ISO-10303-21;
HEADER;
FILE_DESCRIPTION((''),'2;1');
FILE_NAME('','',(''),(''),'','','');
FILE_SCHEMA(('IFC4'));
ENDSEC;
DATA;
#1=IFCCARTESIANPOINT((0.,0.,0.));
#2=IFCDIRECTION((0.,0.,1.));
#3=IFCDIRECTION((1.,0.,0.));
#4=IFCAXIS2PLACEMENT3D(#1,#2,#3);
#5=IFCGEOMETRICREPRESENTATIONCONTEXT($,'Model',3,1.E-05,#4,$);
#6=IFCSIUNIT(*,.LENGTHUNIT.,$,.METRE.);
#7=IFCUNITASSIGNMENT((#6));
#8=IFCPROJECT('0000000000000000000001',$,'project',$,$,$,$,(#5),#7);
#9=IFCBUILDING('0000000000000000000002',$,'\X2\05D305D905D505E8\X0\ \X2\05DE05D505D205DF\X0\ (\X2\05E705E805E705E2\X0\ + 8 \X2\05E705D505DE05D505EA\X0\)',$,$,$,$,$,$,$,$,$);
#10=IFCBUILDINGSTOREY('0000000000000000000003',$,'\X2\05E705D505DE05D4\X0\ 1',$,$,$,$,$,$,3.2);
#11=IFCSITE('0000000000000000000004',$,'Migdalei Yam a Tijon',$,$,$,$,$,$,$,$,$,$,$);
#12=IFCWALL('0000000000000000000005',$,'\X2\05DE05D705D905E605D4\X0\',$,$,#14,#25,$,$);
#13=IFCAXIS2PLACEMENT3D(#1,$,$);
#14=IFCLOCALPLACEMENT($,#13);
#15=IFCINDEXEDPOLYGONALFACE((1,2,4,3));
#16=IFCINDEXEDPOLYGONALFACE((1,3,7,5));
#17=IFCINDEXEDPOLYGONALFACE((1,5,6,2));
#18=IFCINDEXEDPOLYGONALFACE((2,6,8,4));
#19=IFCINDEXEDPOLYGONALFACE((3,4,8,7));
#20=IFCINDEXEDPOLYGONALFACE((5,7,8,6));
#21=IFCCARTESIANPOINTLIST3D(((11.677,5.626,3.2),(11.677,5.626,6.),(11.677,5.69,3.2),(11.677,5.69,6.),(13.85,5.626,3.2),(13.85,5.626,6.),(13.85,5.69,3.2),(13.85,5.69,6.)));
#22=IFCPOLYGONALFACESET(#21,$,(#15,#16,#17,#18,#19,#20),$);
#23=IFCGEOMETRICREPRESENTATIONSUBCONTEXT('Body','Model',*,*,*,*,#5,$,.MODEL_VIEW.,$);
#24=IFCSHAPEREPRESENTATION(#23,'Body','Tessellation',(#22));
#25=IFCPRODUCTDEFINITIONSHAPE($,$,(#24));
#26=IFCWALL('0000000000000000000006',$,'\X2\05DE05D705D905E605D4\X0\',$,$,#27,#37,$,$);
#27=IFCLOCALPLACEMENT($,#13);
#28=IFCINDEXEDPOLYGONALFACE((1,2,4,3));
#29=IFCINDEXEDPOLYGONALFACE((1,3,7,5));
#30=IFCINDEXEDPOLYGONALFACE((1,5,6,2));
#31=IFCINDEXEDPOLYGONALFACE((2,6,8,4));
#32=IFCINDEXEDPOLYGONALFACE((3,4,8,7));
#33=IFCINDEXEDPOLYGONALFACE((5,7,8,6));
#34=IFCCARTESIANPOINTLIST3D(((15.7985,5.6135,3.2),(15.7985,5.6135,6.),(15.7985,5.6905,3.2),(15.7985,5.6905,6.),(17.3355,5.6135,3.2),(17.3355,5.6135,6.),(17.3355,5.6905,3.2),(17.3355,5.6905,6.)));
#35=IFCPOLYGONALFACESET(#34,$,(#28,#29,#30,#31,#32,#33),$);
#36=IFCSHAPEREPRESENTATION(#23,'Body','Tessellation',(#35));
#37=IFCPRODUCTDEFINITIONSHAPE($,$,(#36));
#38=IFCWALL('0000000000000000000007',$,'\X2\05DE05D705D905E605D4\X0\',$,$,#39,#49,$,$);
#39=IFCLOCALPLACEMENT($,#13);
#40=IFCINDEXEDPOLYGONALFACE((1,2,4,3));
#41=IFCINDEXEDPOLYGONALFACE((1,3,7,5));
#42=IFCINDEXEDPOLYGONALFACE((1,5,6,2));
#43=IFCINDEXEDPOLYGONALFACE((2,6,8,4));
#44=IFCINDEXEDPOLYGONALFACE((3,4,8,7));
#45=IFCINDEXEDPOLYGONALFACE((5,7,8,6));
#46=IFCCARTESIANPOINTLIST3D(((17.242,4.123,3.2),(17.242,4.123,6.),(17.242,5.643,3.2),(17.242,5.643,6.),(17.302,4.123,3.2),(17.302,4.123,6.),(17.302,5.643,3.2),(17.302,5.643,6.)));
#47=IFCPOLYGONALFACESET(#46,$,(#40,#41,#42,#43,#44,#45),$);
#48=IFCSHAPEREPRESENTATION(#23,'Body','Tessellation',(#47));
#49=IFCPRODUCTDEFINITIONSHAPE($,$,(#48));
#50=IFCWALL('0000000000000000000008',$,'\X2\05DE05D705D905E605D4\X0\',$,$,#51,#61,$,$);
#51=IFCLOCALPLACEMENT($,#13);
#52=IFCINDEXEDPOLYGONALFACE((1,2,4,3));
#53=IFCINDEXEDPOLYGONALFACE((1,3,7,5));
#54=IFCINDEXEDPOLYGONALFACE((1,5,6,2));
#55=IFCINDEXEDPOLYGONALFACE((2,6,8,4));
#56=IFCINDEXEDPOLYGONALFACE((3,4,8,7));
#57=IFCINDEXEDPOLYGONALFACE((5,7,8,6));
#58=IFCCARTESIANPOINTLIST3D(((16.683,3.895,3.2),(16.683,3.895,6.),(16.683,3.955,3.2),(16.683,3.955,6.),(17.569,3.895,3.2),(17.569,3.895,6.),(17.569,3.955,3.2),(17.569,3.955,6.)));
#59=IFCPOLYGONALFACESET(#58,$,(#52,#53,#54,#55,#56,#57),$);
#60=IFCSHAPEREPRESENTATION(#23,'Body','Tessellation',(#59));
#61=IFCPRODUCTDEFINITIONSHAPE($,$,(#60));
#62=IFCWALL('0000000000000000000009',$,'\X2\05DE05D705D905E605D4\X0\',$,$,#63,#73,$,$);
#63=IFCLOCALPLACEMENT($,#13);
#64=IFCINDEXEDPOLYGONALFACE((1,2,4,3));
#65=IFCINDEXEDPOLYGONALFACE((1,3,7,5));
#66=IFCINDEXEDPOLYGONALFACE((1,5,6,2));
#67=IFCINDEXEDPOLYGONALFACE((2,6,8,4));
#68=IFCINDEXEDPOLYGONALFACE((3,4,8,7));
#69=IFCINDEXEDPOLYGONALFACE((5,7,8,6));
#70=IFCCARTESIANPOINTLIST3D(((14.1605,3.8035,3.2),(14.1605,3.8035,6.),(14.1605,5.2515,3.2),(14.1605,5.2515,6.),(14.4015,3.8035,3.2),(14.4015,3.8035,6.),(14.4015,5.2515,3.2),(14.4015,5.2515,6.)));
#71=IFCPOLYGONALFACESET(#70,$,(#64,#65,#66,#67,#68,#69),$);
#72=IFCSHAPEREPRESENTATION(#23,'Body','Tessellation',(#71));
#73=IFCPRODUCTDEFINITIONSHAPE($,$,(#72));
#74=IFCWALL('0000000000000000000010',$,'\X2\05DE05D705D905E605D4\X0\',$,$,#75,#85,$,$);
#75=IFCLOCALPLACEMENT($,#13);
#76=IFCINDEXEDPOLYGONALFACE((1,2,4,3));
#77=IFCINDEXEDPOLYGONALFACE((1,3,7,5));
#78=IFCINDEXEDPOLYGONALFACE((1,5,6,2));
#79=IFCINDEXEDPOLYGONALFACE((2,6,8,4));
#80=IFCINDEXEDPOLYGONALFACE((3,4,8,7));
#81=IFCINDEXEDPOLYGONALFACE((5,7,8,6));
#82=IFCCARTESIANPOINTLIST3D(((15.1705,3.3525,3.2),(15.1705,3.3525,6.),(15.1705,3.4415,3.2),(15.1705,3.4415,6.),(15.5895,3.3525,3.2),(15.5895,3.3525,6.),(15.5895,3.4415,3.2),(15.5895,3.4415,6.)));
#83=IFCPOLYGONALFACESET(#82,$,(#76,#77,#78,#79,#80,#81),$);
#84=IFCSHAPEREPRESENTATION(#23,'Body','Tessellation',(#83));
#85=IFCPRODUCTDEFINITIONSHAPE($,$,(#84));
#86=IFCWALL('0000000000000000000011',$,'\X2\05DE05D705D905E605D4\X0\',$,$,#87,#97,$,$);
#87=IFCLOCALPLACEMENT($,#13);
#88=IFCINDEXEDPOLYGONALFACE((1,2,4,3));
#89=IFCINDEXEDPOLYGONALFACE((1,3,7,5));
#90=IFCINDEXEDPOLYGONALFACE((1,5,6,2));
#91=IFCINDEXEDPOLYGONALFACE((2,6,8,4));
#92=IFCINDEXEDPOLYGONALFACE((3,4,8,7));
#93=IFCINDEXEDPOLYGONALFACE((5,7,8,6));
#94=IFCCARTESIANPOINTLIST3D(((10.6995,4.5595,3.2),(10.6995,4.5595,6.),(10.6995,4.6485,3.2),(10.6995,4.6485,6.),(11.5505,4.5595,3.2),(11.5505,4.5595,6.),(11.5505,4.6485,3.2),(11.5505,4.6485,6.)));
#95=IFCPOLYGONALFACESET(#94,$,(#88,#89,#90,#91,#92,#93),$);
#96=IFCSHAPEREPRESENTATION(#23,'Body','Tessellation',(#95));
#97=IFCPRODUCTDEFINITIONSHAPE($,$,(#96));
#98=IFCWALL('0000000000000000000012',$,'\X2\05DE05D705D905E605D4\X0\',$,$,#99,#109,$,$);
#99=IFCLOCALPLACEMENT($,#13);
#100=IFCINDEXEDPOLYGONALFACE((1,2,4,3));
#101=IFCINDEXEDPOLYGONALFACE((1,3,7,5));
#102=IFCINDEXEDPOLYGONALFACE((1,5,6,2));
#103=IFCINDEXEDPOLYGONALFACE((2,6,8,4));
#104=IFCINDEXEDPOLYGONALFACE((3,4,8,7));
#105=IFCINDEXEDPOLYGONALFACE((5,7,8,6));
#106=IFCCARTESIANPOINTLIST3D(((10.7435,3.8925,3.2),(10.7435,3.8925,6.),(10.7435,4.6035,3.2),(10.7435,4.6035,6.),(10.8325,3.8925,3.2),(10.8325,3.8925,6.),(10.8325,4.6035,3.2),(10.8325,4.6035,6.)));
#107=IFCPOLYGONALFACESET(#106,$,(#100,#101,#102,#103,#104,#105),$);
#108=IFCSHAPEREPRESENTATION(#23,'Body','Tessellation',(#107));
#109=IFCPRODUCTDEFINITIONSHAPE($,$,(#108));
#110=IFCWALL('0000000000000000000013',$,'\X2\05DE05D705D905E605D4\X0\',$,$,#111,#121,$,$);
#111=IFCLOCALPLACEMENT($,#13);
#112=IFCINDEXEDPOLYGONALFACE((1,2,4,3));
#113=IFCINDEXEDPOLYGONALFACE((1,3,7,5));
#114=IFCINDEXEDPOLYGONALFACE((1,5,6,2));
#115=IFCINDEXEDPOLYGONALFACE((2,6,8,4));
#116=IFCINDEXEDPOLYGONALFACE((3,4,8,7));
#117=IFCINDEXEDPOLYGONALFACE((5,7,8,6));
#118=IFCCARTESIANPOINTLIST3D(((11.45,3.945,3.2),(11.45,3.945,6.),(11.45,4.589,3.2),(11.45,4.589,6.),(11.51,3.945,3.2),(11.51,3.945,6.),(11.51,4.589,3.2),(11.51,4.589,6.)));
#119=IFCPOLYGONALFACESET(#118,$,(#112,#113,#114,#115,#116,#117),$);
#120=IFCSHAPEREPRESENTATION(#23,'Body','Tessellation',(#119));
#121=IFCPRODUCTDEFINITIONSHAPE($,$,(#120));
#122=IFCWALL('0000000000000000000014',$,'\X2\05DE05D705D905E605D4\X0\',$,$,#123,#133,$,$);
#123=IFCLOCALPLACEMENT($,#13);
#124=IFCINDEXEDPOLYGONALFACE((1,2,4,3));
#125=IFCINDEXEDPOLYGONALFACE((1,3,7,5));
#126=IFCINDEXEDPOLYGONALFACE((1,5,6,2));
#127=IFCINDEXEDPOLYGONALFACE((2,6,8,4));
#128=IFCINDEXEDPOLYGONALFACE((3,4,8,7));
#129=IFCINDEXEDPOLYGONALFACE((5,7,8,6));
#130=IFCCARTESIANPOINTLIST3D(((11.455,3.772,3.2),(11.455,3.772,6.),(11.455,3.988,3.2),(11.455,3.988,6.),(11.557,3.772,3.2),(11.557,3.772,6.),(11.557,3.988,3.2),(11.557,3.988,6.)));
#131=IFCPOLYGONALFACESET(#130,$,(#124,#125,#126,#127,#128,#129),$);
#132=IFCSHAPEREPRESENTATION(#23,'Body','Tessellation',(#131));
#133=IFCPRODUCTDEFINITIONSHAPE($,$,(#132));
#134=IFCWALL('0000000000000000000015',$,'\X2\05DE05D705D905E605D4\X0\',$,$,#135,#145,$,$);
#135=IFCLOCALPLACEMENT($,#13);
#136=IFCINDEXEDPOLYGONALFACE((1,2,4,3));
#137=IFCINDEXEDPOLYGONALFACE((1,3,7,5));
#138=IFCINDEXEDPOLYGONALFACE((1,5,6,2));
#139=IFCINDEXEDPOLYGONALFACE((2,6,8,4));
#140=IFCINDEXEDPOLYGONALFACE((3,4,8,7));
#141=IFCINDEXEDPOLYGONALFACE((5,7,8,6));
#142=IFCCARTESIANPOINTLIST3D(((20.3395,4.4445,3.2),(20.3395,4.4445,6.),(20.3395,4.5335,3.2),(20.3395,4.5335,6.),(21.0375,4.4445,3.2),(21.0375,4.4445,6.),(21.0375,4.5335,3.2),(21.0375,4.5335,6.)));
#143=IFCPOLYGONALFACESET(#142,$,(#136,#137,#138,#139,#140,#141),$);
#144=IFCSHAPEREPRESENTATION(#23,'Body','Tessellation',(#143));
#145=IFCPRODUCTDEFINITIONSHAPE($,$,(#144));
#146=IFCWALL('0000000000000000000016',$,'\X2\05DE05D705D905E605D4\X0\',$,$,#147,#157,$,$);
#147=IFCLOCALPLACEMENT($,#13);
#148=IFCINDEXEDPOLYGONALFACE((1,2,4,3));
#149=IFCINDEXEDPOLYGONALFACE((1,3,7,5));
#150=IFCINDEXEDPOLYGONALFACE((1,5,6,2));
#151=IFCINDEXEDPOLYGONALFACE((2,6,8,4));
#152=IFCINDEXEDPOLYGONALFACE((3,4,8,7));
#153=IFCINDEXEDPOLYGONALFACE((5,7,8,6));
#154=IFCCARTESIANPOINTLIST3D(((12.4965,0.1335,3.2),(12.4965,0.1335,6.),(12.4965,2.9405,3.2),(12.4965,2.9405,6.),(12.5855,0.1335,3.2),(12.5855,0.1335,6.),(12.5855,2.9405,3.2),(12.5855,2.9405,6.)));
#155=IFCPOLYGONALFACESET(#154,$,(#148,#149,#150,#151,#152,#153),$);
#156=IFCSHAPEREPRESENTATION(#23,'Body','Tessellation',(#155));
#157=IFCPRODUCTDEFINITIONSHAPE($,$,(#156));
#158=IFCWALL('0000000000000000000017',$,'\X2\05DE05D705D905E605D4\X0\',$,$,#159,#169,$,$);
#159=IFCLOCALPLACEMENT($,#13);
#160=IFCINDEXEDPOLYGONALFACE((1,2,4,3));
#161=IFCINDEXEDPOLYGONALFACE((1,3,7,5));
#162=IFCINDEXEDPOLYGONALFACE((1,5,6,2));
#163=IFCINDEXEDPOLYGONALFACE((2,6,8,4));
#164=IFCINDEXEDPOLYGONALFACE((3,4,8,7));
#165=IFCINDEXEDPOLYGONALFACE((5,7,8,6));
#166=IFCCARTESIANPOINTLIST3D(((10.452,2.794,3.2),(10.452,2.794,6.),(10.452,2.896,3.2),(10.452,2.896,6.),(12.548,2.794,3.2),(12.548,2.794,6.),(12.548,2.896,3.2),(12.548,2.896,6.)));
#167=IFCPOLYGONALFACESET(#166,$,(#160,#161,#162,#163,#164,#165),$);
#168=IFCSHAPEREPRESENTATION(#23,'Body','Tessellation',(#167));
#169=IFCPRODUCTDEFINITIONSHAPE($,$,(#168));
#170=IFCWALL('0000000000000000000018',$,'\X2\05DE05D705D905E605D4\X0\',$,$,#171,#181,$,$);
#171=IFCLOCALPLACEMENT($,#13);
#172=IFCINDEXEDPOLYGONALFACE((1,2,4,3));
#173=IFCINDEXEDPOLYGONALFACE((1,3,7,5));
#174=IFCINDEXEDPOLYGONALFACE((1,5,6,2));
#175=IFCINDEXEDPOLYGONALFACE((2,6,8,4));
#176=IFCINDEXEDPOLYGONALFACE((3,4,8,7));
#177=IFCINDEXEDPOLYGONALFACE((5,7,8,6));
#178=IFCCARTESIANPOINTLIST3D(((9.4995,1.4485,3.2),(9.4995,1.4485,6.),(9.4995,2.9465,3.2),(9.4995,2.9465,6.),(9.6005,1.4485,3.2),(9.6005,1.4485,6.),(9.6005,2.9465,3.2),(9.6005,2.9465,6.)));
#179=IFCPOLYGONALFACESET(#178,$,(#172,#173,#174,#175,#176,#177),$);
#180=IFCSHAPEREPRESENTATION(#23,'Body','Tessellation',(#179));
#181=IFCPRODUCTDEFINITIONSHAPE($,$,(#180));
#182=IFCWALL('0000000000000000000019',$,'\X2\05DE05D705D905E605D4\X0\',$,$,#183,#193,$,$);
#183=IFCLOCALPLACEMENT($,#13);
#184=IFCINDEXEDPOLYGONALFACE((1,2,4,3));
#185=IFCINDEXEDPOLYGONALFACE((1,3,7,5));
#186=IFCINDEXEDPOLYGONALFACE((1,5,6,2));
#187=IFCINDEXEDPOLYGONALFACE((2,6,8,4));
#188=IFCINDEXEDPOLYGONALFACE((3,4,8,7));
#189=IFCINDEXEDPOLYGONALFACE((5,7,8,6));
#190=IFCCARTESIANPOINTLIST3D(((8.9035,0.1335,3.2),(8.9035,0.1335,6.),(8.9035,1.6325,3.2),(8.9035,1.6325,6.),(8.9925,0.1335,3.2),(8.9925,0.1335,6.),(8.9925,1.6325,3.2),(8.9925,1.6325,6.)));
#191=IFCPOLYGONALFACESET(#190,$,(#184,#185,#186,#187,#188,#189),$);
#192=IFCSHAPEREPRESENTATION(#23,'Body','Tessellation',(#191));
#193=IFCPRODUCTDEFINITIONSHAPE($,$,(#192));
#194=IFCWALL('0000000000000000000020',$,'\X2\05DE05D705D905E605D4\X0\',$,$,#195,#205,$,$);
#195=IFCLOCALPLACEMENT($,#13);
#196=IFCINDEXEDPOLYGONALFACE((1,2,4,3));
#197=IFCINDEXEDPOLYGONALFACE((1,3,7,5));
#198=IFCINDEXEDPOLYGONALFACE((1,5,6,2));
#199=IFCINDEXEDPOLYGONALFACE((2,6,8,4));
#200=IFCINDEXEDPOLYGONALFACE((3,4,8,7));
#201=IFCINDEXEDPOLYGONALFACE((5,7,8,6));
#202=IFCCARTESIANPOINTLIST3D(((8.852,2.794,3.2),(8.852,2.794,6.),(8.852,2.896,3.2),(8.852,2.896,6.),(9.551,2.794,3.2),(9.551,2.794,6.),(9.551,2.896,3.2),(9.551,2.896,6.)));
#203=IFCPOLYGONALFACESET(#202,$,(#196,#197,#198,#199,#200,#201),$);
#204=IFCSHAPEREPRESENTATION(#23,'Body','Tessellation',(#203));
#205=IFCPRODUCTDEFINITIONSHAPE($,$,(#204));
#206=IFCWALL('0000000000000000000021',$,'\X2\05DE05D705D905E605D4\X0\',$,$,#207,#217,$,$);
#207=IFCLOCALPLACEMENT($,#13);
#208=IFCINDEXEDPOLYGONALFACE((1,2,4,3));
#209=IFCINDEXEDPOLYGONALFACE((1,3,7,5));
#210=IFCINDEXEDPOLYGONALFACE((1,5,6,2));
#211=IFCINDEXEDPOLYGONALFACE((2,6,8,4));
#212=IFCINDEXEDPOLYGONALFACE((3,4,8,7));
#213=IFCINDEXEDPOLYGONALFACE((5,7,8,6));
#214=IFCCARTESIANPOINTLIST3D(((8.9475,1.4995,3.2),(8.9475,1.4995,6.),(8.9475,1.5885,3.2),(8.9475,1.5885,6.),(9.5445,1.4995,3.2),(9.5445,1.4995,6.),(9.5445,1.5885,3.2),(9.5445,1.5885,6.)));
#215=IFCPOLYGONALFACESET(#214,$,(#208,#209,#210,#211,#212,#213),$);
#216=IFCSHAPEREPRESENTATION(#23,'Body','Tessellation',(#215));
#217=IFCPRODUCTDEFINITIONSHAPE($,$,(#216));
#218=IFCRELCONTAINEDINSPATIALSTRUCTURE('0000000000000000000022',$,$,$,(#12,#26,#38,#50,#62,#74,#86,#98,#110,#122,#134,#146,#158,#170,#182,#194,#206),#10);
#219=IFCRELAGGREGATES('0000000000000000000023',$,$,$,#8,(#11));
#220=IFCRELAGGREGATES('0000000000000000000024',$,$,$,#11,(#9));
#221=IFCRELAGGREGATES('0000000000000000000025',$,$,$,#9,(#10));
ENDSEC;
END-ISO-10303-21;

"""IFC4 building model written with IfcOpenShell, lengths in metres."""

from ifc_helpers import new_model, si_unit, frame, origin_with_axes, context, subcontext, project, spatial, line, indexed_curve, outline, extrude, element, save


model = new_model("IFC4")

# Units and contexts
model_context = context("Model", 3, precision=1e-05, world=origin_with_axes())
body_context = subcontext(model_context, "Body", "Model", "MODEL_VIEW")
ifc_project = project(units=[si_unit("LENGTHUNIT", "METRE")], contexts=[model_context])

# Site, building, storey
site = spatial("IfcSite", under=ifc_project, Name="Migdalei Yam a Tijon")
building = spatial("IfcBuilding", under=site, Name="דיור מוגן (קרקע + 8 קומות)")
storey = spatial("IfcBuildingStorey", under=building, Name="קומה 1", Elevation=3.2)

# Walls
element("IfcWall", 1, inside=storey, Name="מחיצה", context=body_context, shape_type="SweptSolid", body=[
    extrude(outline(indexed_curve([(0.0, 0.0), (2.173, 0.0), (2.173, 0.064), (0.0, 0.064)], segments=[line(1, 2, 3, 4, 1)])), frame((11.677, 5.626, 3.2), z_axis=(0.0, 0.0, 1.0), x_axis=(1.0, 0.0, 0.0)), (0.0, 0.0, 1.0), 2.8),
])
element("IfcWall", 2, inside=storey, Name="מחיצה", context=body_context, shape_type="SweptSolid", body=[
    extrude(outline(indexed_curve([(0.0, 0.0), (1.537, 0.0), (1.537, 0.077), (0.0, 0.077)], segments=[line(1, 2, 3, 4, 1)])), frame((15.7985, 5.6135, 3.2), z_axis=(0.0, 0.0, 1.0), x_axis=(1.0, 0.0, 0.0)), (0.0, 0.0, 1.0), 2.8),
])
element("IfcWall", 3, inside=storey, Name="מחיצה", context=body_context, shape_type="SweptSolid", body=[
    extrude(outline(indexed_curve([(0.0, 0.0), (0.06, 0.0), (0.06, 1.52), (0.0, 1.52)], segments=[line(1, 2, 3, 4, 1)])), frame((17.242, 4.123, 3.2), z_axis=(0.0, 0.0, 1.0), x_axis=(1.0, 0.0, 0.0)), (0.0, 0.0, 1.0), 2.8),
])
element("IfcWall", 4, inside=storey, Name="מחיצה", context=body_context, shape_type="SweptSolid", body=[
    extrude(outline(indexed_curve([(0.0, 0.0), (0.886, 0.0), (0.886, 0.06), (0.0, 0.06)], segments=[line(1, 2, 3, 4, 1)])), frame((16.683, 3.895, 3.2), z_axis=(0.0, 0.0, 1.0), x_axis=(1.0, 0.0, 0.0)), (0.0, 0.0, 1.0), 2.8),
])
element("IfcWall", 5, inside=storey, Name="מחיצה", context=body_context, shape_type="SweptSolid", body=[
    extrude(outline(indexed_curve([(0.0, 0.0), (0.241, 0.0), (0.241, 1.448), (0.0, 1.448)], segments=[line(1, 2, 3, 4, 1)])), frame((14.1605, 3.8035, 3.2), z_axis=(0.0, 0.0, 1.0), x_axis=(1.0, 0.0, 0.0)), (0.0, 0.0, 1.0), 2.8),
])
element("IfcWall", 6, inside=storey, Name="מחיצה", context=body_context, shape_type="SweptSolid", body=[
    extrude(outline(indexed_curve([(0.0, 0.0), (0.419, 0.0), (0.419, 0.089), (0.0, 0.089)], segments=[line(1, 2, 3, 4, 1)])), frame((15.1705, 3.3525, 3.2), z_axis=(0.0, 0.0, 1.0), x_axis=(1.0, 0.0, 0.0)), (0.0, 0.0, 1.0), 2.8),
])
element("IfcWall", 7, inside=storey, Name="מחיצה", context=body_context, shape_type="SweptSolid", body=[
    extrude(outline(indexed_curve([(0.0, 0.0), (0.851, 0.0), (0.851, 0.089), (0.0, 0.089)], segments=[line(1, 2, 3, 4, 1)])), frame((10.6995, 4.5595, 3.2), z_axis=(0.0, 0.0, 1.0), x_axis=(1.0, 0.0, 0.0)), (0.0, 0.0, 1.0), 2.8),
])
element("IfcWall", 8, inside=storey, Name="מחיצה", context=body_context, shape_type="SweptSolid", body=[
    extrude(outline(indexed_curve([(0.0, 0.0), (0.089, 0.0), (0.089, 0.711), (0.0, 0.711)], segments=[line(1, 2, 3, 4, 1)])), frame((10.7435, 3.8925, 3.2), z_axis=(0.0, 0.0, 1.0), x_axis=(1.0, 0.0, 0.0)), (0.0, 0.0, 1.0), 2.8),
])
element("IfcWall", 9, inside=storey, Name="מחיצה", context=body_context, shape_type="SweptSolid", body=[
    extrude(outline(indexed_curve([(0.0, 0.0), (0.06, 0.0), (0.06, 0.644), (0.0, 0.644)], segments=[line(1, 2, 3, 4, 1)])), frame((11.45, 3.945, 3.2), z_axis=(0.0, 0.0, 1.0), x_axis=(1.0, 0.0, 0.0)), (0.0, 0.0, 1.0), 2.8),
])
element("IfcWall", 10, inside=storey, Name="מחיצה", context=body_context, shape_type="SweptSolid", body=[
    extrude(outline(indexed_curve([(0.0, 0.0), (0.102, 0.0), (0.102, 0.216), (0.0, 0.216)], segments=[line(1, 2, 3, 4, 1)])), frame((11.455, 3.772, 3.2), z_axis=(0.0, 0.0, 1.0), x_axis=(1.0, 0.0, 0.0)), (0.0, 0.0, 1.0), 2.8),
])
element("IfcWall", 11, inside=storey, Name="מחיצה", context=body_context, shape_type="SweptSolid", body=[
    extrude(outline(indexed_curve([(0.0, 0.0), (0.698, 0.0), (0.698, 0.089), (0.0, 0.089)], segments=[line(1, 2, 3, 4, 1)])), frame((20.3395, 4.4445, 3.2), z_axis=(0.0, 0.0, 1.0), x_axis=(1.0, 0.0, 0.0)), (0.0, 0.0, 1.0), 2.8),
])
element("IfcWall", 12, inside=storey, Name="מחיצה", context=body_context, shape_type="SweptSolid", body=[
    extrude(outline(indexed_curve([(0.0, 0.0), (0.089, 0.0), (0.089, 2.807), (0.0, 2.807)], segments=[line(1, 2, 3, 4, 1)])), frame((12.4965, 0.1335, 3.2), z_axis=(0.0, 0.0, 1.0), x_axis=(1.0, 0.0, 0.0)), (0.0, 0.0, 1.0), 2.8),
])
element("IfcWall", 13, inside=storey, Name="מחיצה", context=body_context, shape_type="SweptSolid", body=[
    extrude(outline(indexed_curve([(0.0, 0.0), (2.096, 0.0), (2.096, 0.102), (0.0, 0.102)], segments=[line(1, 2, 3, 4, 1)])), frame((10.452, 2.794, 3.2), z_axis=(0.0, 0.0, 1.0), x_axis=(1.0, 0.0, 0.0)), (0.0, 0.0, 1.0), 2.8),
])
element("IfcWall", 14, inside=storey, Name="מחיצה", context=body_context, shape_type="SweptSolid", body=[
    extrude(outline(indexed_curve([(0.0, 0.0), (0.101, 0.0), (0.101, 1.498), (0.0, 1.498)], segments=[line(1, 2, 3, 4, 1)])), frame((9.4995, 1.4485, 3.2), z_axis=(0.0, 0.0, 1.0), x_axis=(1.0, 0.0, 0.0)), (0.0, 0.0, 1.0), 2.8),
])
element("IfcWall", 15, inside=storey, Name="מחיצה", context=body_context, shape_type="SweptSolid", body=[
    extrude(outline(indexed_curve([(0.0, 0.0), (0.089, 0.0), (0.089, 1.499), (0.0, 1.499)], segments=[line(1, 2, 3, 4, 1)])), frame((8.9035, 0.1335, 3.2), z_axis=(0.0, 0.0, 1.0), x_axis=(1.0, 0.0, 0.0)), (0.0, 0.0, 1.0), 2.8),
])
element("IfcWall", 16, inside=storey, Name="מחיצה", context=body_context, shape_type="SweptSolid", body=[
    extrude(outline(indexed_curve([(0.0, 0.0), (0.699, 0.0), (0.699, 0.102), (0.0, 0.102)], segments=[line(1, 2, 3, 4, 1)])), frame((8.852, 2.794, 3.2), z_axis=(0.0, 0.0, 1.0), x_axis=(1.0, 0.0, 0.0)), (0.0, 0.0, 1.0), 2.8),
])
element("IfcWall", 17, inside=storey, Name="מחיצה", context=body_context, shape_type="SweptSolid", body=[
    extrude(outline(indexed_curve([(0.0, 0.0), (0.597, 0.0), (0.597, 0.089), (0.0, 0.089)], segments=[line(1, 2, 3, 4, 1)])), frame((8.9475, 1.4995, 3.2), z_axis=(0.0, 0.0, 1.0), x_axis=(1.0, 0.0, 0.0)), (0.0, 0.0, 1.0), 2.8),
])

save(model, "model.ifc")
